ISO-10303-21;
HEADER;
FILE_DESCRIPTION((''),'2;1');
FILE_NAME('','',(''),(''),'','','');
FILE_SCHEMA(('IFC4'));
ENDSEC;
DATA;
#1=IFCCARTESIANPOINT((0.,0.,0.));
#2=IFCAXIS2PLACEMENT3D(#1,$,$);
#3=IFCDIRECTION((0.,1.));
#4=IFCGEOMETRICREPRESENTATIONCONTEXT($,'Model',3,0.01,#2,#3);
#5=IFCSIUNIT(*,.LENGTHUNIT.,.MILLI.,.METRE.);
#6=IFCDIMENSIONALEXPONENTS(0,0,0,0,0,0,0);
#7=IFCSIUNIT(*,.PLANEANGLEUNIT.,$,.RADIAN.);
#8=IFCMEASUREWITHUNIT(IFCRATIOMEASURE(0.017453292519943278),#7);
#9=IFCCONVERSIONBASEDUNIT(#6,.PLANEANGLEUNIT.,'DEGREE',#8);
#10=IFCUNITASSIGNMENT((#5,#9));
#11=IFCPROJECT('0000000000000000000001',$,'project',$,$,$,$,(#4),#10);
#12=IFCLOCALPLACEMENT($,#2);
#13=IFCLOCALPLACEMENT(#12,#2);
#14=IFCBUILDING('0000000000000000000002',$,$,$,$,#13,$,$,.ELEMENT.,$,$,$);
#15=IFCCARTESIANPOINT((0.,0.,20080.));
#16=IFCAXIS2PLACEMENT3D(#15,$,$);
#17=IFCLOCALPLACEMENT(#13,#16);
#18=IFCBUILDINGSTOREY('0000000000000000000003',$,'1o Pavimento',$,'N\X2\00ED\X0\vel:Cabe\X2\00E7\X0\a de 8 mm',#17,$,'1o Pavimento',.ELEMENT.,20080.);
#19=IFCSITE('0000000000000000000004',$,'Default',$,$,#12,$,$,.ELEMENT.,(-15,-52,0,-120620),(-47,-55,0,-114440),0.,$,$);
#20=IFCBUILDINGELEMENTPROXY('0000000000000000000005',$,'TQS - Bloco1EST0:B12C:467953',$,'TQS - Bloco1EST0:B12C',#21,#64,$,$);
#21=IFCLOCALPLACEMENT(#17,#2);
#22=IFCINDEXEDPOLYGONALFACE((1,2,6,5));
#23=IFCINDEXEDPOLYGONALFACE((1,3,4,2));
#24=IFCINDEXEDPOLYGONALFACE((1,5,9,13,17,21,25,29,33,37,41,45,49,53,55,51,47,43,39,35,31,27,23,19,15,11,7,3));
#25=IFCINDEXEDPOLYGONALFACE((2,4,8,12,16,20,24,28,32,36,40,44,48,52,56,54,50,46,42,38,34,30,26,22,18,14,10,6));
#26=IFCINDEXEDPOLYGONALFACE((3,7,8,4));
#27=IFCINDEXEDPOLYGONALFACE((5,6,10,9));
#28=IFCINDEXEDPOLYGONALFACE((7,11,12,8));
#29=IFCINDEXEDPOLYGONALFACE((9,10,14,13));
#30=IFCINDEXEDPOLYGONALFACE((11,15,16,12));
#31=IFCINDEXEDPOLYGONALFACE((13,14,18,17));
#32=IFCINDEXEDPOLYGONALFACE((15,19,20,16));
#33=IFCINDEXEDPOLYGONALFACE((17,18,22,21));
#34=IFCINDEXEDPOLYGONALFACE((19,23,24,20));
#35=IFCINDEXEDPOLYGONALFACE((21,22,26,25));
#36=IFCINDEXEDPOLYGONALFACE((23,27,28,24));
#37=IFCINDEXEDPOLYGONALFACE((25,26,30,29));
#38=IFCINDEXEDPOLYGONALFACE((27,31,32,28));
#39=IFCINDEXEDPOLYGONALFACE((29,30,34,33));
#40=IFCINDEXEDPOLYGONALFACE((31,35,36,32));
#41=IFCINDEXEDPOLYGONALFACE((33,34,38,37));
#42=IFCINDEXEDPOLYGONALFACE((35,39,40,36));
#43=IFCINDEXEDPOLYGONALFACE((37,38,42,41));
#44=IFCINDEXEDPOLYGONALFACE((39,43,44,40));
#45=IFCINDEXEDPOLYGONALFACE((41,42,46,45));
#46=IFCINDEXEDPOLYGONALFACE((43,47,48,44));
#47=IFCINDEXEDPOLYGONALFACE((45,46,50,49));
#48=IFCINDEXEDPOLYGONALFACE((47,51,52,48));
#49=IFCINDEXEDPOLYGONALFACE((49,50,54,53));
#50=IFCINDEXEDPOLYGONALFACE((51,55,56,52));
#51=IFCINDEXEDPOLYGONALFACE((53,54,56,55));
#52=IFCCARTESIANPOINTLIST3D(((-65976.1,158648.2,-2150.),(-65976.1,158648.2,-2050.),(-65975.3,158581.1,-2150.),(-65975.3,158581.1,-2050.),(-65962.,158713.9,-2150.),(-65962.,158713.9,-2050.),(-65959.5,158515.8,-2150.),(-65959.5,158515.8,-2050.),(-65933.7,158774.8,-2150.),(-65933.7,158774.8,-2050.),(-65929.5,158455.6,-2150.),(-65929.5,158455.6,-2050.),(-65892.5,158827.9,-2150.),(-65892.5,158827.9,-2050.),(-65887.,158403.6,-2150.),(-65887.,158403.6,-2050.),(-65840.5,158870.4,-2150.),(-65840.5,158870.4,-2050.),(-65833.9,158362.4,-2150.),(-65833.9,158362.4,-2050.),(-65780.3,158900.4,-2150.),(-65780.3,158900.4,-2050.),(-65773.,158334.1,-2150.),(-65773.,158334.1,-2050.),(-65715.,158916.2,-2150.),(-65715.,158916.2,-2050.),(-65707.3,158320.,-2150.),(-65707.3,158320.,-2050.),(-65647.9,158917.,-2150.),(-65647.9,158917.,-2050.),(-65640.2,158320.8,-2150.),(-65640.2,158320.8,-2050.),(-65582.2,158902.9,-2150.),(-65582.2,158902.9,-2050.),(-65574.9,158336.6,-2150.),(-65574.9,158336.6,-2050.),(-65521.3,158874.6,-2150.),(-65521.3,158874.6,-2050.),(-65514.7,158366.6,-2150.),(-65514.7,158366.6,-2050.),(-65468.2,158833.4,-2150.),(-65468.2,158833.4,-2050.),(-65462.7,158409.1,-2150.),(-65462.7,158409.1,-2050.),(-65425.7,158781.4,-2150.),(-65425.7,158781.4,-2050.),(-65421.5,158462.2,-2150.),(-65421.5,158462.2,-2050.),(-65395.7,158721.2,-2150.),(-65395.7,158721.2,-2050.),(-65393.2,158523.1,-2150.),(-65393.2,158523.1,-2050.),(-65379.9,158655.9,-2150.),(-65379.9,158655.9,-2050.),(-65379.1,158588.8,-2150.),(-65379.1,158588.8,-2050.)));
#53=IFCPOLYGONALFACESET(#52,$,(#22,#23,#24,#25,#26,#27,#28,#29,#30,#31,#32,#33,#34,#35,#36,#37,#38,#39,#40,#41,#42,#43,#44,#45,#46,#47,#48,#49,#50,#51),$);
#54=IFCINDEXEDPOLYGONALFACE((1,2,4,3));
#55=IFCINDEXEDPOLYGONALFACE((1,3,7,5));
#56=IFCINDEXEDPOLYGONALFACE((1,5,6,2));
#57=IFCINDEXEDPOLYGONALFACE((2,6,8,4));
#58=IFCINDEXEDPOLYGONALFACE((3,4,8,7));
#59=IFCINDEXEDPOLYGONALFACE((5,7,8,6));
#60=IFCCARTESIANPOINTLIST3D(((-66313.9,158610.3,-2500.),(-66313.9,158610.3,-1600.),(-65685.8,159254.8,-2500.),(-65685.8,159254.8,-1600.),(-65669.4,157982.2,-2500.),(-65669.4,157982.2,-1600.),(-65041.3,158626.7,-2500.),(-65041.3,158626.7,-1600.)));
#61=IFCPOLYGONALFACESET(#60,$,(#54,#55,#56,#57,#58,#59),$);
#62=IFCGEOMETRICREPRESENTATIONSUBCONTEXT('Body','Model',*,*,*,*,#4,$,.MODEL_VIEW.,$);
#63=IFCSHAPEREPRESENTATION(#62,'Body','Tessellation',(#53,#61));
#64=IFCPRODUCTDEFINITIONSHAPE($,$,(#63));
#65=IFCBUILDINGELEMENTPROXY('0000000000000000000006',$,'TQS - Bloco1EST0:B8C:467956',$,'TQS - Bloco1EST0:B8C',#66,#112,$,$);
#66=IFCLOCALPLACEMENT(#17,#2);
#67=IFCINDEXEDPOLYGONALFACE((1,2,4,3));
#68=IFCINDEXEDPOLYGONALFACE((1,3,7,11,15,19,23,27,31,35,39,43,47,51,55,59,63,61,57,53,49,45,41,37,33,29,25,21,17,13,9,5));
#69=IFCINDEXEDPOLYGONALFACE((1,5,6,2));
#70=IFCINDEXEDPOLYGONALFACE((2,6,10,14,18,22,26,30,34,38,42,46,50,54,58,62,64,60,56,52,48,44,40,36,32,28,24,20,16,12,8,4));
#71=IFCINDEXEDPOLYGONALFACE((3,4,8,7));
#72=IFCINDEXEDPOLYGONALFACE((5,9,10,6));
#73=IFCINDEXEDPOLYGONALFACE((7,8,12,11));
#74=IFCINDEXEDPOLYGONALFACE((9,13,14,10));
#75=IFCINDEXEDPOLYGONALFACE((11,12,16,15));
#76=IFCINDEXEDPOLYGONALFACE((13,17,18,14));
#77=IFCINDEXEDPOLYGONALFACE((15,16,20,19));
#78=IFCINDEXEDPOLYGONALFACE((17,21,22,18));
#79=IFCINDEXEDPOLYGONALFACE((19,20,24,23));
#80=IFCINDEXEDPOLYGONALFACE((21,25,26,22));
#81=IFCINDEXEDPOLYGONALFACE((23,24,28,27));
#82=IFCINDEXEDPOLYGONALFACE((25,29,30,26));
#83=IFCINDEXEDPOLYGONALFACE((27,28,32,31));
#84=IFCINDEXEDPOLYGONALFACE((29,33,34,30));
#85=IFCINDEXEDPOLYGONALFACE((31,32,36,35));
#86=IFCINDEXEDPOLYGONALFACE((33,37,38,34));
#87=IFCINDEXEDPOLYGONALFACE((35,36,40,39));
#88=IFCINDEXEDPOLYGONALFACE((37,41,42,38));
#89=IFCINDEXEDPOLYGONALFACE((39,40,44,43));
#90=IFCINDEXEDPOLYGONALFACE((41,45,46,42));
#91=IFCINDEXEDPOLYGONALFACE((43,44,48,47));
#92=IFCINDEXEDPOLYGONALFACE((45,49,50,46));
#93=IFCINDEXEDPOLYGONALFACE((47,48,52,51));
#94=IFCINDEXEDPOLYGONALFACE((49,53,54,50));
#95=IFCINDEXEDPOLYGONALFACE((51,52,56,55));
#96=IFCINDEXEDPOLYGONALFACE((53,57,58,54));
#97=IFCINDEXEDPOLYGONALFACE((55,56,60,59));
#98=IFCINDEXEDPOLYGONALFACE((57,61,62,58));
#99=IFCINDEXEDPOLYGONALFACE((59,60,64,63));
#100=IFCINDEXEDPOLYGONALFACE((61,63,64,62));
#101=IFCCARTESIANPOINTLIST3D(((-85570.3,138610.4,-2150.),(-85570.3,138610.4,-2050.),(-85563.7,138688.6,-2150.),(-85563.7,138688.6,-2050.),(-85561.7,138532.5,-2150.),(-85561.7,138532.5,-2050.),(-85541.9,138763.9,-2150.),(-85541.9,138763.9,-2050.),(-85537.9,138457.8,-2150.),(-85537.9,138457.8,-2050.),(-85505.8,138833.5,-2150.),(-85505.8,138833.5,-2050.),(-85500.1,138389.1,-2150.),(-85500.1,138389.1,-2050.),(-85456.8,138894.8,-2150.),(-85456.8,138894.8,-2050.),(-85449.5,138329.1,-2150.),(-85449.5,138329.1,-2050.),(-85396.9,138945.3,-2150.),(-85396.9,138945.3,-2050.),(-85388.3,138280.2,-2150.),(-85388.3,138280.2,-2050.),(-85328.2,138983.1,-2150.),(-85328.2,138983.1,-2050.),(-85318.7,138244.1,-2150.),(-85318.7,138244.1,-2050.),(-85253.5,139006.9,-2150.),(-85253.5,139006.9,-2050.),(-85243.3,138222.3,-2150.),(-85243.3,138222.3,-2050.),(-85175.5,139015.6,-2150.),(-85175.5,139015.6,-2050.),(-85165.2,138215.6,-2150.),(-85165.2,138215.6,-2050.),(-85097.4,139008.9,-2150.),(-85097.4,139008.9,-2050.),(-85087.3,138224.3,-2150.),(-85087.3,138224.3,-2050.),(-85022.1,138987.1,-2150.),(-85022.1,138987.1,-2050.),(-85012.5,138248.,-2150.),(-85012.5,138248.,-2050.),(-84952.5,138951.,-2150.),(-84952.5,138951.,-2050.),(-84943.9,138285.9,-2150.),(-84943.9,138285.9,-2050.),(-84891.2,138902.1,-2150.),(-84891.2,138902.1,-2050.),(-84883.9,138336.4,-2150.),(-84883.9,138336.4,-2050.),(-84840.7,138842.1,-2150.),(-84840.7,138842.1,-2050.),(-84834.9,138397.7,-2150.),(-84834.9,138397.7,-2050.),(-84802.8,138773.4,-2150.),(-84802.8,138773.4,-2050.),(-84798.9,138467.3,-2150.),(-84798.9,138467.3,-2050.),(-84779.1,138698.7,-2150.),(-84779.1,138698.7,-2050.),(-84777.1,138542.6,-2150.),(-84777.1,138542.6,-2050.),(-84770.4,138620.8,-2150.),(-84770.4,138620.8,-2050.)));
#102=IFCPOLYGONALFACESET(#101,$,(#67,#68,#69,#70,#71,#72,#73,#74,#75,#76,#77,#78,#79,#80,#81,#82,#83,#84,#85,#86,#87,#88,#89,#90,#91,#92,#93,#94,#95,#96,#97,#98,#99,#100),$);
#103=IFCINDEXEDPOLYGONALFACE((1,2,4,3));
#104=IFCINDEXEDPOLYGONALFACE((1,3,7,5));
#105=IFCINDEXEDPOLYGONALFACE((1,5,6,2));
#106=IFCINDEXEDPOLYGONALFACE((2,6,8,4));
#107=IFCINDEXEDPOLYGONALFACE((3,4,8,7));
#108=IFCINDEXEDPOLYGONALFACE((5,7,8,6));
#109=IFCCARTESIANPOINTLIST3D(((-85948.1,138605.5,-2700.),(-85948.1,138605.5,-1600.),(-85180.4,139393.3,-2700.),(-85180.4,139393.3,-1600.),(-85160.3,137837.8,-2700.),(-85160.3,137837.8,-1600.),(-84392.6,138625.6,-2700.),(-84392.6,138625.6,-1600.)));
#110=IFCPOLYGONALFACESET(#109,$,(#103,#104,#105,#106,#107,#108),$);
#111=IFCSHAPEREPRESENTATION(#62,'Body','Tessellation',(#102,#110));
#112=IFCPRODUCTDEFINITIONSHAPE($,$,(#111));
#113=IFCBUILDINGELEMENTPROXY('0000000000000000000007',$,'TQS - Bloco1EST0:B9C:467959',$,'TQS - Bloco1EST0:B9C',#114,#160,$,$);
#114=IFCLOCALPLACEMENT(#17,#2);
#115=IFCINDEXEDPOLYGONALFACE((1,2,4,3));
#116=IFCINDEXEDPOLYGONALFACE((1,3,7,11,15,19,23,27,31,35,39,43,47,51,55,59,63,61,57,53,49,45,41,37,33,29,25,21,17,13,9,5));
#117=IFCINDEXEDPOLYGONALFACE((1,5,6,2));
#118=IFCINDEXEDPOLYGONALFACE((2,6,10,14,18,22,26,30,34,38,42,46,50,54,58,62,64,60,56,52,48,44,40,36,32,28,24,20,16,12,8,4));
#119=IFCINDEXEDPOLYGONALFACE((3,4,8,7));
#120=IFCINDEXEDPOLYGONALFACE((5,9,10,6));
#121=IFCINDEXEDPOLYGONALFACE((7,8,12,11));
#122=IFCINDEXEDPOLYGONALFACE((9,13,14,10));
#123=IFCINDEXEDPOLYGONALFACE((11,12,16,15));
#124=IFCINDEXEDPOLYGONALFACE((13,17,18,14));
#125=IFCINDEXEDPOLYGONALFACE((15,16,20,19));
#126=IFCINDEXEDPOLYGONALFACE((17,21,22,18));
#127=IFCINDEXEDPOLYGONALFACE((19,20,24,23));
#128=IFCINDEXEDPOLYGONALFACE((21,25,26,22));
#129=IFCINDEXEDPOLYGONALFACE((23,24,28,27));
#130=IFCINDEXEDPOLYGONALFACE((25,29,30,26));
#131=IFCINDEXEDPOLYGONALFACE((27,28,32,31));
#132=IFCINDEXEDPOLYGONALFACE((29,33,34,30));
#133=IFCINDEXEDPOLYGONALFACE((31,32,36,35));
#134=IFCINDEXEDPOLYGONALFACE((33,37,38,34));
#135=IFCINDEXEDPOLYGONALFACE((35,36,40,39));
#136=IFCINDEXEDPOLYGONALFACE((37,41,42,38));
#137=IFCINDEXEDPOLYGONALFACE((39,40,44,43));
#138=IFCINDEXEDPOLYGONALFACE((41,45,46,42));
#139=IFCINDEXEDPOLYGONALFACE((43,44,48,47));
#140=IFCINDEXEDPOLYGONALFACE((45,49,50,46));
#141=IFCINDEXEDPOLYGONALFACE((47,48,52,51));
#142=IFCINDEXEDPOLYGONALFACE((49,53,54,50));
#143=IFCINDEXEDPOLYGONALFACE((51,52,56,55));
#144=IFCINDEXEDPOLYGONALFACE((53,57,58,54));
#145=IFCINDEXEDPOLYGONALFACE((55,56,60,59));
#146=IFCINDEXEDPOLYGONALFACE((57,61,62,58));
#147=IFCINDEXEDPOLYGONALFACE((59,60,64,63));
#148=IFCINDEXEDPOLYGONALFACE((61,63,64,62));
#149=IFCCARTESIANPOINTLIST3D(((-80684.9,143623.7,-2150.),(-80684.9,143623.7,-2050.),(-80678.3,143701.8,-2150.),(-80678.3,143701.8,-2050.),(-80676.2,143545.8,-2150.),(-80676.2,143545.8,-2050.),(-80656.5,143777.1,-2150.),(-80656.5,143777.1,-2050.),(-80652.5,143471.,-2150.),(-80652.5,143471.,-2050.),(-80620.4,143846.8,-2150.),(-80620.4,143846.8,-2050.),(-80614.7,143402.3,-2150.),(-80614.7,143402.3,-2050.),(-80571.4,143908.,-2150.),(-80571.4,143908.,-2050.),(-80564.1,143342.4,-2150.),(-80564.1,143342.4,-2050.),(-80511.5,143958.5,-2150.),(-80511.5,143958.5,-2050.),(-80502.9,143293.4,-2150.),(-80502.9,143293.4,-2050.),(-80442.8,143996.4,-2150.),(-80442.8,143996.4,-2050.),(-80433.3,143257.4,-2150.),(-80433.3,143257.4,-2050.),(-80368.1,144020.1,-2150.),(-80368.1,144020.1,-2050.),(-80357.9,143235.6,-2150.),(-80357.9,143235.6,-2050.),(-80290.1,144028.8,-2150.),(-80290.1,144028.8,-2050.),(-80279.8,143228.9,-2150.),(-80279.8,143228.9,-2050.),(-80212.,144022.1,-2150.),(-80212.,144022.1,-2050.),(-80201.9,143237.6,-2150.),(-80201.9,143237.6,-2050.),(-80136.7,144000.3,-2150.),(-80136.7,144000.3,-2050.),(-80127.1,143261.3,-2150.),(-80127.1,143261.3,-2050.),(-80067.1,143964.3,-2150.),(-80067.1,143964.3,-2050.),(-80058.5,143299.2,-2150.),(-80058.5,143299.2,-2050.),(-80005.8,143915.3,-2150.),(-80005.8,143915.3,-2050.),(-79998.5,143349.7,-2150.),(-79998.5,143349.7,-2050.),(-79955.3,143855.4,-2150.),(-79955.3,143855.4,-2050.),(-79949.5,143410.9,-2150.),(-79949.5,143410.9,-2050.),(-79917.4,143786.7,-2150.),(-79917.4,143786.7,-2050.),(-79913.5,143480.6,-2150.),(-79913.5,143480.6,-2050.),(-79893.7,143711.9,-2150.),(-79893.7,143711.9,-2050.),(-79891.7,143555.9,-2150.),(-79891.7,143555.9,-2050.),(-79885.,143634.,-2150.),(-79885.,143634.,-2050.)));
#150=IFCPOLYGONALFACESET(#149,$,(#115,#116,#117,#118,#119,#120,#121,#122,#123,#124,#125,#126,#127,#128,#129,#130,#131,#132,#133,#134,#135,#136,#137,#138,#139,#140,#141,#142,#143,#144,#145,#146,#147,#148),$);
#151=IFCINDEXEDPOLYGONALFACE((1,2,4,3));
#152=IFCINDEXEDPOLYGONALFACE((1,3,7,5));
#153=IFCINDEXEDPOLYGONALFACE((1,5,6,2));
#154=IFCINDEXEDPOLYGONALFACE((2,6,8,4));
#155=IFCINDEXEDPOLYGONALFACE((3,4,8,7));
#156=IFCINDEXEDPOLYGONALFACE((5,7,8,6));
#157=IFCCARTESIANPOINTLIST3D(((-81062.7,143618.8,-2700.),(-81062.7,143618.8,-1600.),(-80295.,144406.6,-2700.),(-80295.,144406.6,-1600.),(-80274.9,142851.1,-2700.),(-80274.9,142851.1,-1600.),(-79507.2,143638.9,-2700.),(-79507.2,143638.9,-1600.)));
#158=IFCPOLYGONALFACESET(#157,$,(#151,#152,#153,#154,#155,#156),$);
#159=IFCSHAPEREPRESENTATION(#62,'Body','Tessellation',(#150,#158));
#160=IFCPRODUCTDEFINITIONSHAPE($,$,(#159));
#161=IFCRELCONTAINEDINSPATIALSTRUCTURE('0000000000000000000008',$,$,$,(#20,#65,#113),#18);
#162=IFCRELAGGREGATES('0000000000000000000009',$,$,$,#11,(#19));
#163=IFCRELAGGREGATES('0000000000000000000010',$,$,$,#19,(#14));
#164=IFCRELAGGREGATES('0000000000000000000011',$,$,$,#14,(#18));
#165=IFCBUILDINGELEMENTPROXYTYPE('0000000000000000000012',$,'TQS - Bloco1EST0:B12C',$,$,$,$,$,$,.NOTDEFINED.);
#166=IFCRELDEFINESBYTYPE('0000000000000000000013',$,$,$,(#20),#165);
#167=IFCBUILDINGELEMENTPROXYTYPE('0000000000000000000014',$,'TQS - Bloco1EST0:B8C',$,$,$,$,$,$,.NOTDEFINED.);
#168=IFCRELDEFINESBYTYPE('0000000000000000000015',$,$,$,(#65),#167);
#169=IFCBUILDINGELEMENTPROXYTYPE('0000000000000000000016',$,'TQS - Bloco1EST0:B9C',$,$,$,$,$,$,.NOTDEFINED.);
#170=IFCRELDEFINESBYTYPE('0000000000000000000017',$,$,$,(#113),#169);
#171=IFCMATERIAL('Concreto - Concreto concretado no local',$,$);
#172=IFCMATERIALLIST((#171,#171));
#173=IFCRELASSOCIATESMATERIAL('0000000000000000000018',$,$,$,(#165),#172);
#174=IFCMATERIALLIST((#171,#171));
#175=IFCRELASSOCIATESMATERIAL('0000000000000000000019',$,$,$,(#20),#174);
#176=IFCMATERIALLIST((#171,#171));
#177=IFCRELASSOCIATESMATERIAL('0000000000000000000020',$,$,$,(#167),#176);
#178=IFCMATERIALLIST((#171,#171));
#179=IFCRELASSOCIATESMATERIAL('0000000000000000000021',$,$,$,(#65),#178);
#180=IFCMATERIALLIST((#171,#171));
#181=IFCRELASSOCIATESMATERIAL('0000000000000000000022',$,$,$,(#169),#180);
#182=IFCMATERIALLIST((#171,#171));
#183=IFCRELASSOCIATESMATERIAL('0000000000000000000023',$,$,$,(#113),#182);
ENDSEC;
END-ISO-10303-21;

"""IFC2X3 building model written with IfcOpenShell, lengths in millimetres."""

from ifc_helpers import new_model, entity, si_unit, converted_unit, direction, frame, frame_2d, origin, origin_2d_with_axis, place, context, subcontext, project, spatial, rectangle, circle, extrude, source, transform, mapped, material, material_list, type_object, type_shapes, element, save


model = new_model("IFC2X3")

# Units and contexts
model_context = context("Model", 3, precision=0.01, world=origin(), true_north=direction((0.0, 1.0)))
body_context = subcontext(model_context, "Body", "Model", "MODEL_VIEW")
ifc_project = project(units=[si_unit("LENGTHUNIT", "METRE", prefix="MILLI"), converted_unit("PLANEANGLEUNIT", "DEGREE", entity("IfcRatioMeasure", 0.017453292519943278), si_unit("PLANEANGLEUNIT", "RADIAN"), dimensions=[0, 0, 0, 0, 0, 0, 0])], contexts=[model_context])

# Site, building, storey
site_placement = place(None, origin())
site = spatial("IfcSite", under=ifc_project, at=site_placement, Name="Default", CompositionType="ELEMENT", RefLatitude=(-15, -52, 0, -120620), RefLongitude=(-47, -55, 0, -114440), RefElevation=0.0)
building_placement = place(site_placement, origin())
building = spatial("IfcBuilding", under=site, at=building_placement, CompositionType="ELEMENT")
storey_placement = place(building_placement, frame((0.0, 0.0, 20080.0)))
storey = spatial("IfcBuildingStorey", under=building, at=storey_placement, Name="1o Pavimento", ObjectType="Nível:Cabeça de 8 mm", LongName="1o Pavimento", CompositionType="ELEMENT", Elevation=20080.0)

# Building element proxies
ifc_material_1 = material(Name="Concreto - Concreto concretado no local")
ifc_material_list_1 = material_list([ifc_material_1, ifc_material_1])
ifc_material_list_2 = material_list([ifc_material_1, ifc_material_1])
building_element_proxy_type_1 = type_object("IfcBuildingElementProxyType", Name="TQS - Bloco1EST0:B12C", PredefinedType="NOTDEFINED", material=ifc_material_list_2)
shared_shape_1 = source(origin(), body_context, "Body", "SweptSolid", [
    extrude(circle(Radius=300.0, at=frame_2d((0.0, 0.0), x_axis=(1.0, 0.0))), frame((0.0, 0.0, -550.0)), (0.0, 0.0, 1.0), 100.0),
    extrude(rectangle(XDim=900.0, YDim=900.0, at=origin_2d_with_axis()), frame((0.0, 0.0, -900.0), z_axis=(0.0, 0.0, 1.0), x_axis=(-1.0, 0.0, 0.0)), (0.0, 0.0, 1.0), 900.0),
])
type_shapes(building_element_proxy_type_1, [shared_shape_1])
proxy_1_placement = place(storey_placement, frame((-65677.6, 158618.5, -1600.0), z_axis=(0.0, 0.0, 1.0), x_axis=(0.697915, 0.71618, 0.0)))
element("IfcBuildingElementProxy", 1, at=proxy_1_placement, inside=storey, type_object=building_element_proxy_type_1, material=ifc_material_list_1, Name="TQS - Bloco1EST0:B12C:467953", ObjectType="TQS - Bloco1EST0:B12C", context=body_context, shape_type="MappedRepresentation", body=[
    mapped(shared_shape_1, transform((0.0, 0.0, 0.0), scale=1.0)),
])
ifc_material_list_3 = material_list([ifc_material_1, ifc_material_1])
ifc_material_list_4 = material_list([ifc_material_1, ifc_material_1])
building_element_proxy_type_2 = type_object("IfcBuildingElementProxyType", Name="TQS - Bloco1EST0:B8C", PredefinedType="NOTDEFINED", material=ifc_material_list_4)
shared_shape_2 = source(origin(), body_context, "Body", "SweptSolid", [
    extrude(circle(Radius=400.0, at=frame_2d((0.0, 0.0), x_axis=(1.0, 0.0))), frame((0.0, 0.0, -550.0)), (0.0, 0.0, 1.0), 100.0),
    extrude(rectangle(XDim=1100.0, YDim=1100.0, at=origin_2d_with_axis()), frame((0.0, 0.0, -1100.0), z_axis=(0.0, 0.0, 1.0), x_axis=(-1.0, 0.0, 0.0)), (0.0, 0.0, 1.0), 1100.0),
])
type_shapes(building_element_proxy_type_2, [shared_shape_2])
proxy_2_placement = place(storey_placement, frame((-85170.4, 138615.6, -1600.0), z_axis=(0.0, 0.0, 1.0), x_axis=(0.697915, 0.71618, 0.0)))
element("IfcBuildingElementProxy", 2, at=proxy_2_placement, inside=storey, type_object=building_element_proxy_type_2, material=ifc_material_list_3, Name="TQS - Bloco1EST0:B8C:467956", ObjectType="TQS - Bloco1EST0:B8C", context=body_context, shape_type="MappedRepresentation", body=[
    mapped(shared_shape_2, transform((0.0, 0.0, 0.0), scale=1.0)),
])
ifc_material_list_5 = material_list([ifc_material_1, ifc_material_1])
ifc_material_list_6 = material_list([ifc_material_1, ifc_material_1])
building_element_proxy_type_3 = type_object("IfcBuildingElementProxyType", Name="TQS - Bloco1EST0:B9C", PredefinedType="NOTDEFINED", material=ifc_material_list_6)
shared_shape_3 = source(origin(), body_context, "Body", "SweptSolid", [
    extrude(circle(Radius=400.0, at=frame_2d((0.0, 0.0), x_axis=(1.0, 0.0))), frame((0.0, 0.0, -550.0)), (0.0, 0.0, 1.0), 100.0),
    extrude(rectangle(XDim=1100.0, YDim=1100.0, at=origin_2d_with_axis()), frame((0.0, 0.0, -1100.0), z_axis=(0.0, 0.0, 1.0), x_axis=(-1.0, 0.0, 0.0)), (0.0, 0.0, 1.0), 1100.0),
])
type_shapes(building_element_proxy_type_3, [shared_shape_3])
proxy_3_placement = place(storey_placement, frame((-80285.0, 143628.9, -1600.0), z_axis=(0.0, 0.0, 1.0), x_axis=(0.697915, 0.71618, 0.0)))
element("IfcBuildingElementProxy", 3, at=proxy_3_placement, inside=storey, type_object=building_element_proxy_type_3, material=ifc_material_list_5, Name="TQS - Bloco1EST0:B9C:467959", ObjectType="TQS - Bloco1EST0:B9C", context=body_context, shape_type="MappedRepresentation", body=[
    mapped(shared_shape_3, transform((0.0, 0.0, 0.0), scale=1.0)),
])

save(model, "model.ifc")
